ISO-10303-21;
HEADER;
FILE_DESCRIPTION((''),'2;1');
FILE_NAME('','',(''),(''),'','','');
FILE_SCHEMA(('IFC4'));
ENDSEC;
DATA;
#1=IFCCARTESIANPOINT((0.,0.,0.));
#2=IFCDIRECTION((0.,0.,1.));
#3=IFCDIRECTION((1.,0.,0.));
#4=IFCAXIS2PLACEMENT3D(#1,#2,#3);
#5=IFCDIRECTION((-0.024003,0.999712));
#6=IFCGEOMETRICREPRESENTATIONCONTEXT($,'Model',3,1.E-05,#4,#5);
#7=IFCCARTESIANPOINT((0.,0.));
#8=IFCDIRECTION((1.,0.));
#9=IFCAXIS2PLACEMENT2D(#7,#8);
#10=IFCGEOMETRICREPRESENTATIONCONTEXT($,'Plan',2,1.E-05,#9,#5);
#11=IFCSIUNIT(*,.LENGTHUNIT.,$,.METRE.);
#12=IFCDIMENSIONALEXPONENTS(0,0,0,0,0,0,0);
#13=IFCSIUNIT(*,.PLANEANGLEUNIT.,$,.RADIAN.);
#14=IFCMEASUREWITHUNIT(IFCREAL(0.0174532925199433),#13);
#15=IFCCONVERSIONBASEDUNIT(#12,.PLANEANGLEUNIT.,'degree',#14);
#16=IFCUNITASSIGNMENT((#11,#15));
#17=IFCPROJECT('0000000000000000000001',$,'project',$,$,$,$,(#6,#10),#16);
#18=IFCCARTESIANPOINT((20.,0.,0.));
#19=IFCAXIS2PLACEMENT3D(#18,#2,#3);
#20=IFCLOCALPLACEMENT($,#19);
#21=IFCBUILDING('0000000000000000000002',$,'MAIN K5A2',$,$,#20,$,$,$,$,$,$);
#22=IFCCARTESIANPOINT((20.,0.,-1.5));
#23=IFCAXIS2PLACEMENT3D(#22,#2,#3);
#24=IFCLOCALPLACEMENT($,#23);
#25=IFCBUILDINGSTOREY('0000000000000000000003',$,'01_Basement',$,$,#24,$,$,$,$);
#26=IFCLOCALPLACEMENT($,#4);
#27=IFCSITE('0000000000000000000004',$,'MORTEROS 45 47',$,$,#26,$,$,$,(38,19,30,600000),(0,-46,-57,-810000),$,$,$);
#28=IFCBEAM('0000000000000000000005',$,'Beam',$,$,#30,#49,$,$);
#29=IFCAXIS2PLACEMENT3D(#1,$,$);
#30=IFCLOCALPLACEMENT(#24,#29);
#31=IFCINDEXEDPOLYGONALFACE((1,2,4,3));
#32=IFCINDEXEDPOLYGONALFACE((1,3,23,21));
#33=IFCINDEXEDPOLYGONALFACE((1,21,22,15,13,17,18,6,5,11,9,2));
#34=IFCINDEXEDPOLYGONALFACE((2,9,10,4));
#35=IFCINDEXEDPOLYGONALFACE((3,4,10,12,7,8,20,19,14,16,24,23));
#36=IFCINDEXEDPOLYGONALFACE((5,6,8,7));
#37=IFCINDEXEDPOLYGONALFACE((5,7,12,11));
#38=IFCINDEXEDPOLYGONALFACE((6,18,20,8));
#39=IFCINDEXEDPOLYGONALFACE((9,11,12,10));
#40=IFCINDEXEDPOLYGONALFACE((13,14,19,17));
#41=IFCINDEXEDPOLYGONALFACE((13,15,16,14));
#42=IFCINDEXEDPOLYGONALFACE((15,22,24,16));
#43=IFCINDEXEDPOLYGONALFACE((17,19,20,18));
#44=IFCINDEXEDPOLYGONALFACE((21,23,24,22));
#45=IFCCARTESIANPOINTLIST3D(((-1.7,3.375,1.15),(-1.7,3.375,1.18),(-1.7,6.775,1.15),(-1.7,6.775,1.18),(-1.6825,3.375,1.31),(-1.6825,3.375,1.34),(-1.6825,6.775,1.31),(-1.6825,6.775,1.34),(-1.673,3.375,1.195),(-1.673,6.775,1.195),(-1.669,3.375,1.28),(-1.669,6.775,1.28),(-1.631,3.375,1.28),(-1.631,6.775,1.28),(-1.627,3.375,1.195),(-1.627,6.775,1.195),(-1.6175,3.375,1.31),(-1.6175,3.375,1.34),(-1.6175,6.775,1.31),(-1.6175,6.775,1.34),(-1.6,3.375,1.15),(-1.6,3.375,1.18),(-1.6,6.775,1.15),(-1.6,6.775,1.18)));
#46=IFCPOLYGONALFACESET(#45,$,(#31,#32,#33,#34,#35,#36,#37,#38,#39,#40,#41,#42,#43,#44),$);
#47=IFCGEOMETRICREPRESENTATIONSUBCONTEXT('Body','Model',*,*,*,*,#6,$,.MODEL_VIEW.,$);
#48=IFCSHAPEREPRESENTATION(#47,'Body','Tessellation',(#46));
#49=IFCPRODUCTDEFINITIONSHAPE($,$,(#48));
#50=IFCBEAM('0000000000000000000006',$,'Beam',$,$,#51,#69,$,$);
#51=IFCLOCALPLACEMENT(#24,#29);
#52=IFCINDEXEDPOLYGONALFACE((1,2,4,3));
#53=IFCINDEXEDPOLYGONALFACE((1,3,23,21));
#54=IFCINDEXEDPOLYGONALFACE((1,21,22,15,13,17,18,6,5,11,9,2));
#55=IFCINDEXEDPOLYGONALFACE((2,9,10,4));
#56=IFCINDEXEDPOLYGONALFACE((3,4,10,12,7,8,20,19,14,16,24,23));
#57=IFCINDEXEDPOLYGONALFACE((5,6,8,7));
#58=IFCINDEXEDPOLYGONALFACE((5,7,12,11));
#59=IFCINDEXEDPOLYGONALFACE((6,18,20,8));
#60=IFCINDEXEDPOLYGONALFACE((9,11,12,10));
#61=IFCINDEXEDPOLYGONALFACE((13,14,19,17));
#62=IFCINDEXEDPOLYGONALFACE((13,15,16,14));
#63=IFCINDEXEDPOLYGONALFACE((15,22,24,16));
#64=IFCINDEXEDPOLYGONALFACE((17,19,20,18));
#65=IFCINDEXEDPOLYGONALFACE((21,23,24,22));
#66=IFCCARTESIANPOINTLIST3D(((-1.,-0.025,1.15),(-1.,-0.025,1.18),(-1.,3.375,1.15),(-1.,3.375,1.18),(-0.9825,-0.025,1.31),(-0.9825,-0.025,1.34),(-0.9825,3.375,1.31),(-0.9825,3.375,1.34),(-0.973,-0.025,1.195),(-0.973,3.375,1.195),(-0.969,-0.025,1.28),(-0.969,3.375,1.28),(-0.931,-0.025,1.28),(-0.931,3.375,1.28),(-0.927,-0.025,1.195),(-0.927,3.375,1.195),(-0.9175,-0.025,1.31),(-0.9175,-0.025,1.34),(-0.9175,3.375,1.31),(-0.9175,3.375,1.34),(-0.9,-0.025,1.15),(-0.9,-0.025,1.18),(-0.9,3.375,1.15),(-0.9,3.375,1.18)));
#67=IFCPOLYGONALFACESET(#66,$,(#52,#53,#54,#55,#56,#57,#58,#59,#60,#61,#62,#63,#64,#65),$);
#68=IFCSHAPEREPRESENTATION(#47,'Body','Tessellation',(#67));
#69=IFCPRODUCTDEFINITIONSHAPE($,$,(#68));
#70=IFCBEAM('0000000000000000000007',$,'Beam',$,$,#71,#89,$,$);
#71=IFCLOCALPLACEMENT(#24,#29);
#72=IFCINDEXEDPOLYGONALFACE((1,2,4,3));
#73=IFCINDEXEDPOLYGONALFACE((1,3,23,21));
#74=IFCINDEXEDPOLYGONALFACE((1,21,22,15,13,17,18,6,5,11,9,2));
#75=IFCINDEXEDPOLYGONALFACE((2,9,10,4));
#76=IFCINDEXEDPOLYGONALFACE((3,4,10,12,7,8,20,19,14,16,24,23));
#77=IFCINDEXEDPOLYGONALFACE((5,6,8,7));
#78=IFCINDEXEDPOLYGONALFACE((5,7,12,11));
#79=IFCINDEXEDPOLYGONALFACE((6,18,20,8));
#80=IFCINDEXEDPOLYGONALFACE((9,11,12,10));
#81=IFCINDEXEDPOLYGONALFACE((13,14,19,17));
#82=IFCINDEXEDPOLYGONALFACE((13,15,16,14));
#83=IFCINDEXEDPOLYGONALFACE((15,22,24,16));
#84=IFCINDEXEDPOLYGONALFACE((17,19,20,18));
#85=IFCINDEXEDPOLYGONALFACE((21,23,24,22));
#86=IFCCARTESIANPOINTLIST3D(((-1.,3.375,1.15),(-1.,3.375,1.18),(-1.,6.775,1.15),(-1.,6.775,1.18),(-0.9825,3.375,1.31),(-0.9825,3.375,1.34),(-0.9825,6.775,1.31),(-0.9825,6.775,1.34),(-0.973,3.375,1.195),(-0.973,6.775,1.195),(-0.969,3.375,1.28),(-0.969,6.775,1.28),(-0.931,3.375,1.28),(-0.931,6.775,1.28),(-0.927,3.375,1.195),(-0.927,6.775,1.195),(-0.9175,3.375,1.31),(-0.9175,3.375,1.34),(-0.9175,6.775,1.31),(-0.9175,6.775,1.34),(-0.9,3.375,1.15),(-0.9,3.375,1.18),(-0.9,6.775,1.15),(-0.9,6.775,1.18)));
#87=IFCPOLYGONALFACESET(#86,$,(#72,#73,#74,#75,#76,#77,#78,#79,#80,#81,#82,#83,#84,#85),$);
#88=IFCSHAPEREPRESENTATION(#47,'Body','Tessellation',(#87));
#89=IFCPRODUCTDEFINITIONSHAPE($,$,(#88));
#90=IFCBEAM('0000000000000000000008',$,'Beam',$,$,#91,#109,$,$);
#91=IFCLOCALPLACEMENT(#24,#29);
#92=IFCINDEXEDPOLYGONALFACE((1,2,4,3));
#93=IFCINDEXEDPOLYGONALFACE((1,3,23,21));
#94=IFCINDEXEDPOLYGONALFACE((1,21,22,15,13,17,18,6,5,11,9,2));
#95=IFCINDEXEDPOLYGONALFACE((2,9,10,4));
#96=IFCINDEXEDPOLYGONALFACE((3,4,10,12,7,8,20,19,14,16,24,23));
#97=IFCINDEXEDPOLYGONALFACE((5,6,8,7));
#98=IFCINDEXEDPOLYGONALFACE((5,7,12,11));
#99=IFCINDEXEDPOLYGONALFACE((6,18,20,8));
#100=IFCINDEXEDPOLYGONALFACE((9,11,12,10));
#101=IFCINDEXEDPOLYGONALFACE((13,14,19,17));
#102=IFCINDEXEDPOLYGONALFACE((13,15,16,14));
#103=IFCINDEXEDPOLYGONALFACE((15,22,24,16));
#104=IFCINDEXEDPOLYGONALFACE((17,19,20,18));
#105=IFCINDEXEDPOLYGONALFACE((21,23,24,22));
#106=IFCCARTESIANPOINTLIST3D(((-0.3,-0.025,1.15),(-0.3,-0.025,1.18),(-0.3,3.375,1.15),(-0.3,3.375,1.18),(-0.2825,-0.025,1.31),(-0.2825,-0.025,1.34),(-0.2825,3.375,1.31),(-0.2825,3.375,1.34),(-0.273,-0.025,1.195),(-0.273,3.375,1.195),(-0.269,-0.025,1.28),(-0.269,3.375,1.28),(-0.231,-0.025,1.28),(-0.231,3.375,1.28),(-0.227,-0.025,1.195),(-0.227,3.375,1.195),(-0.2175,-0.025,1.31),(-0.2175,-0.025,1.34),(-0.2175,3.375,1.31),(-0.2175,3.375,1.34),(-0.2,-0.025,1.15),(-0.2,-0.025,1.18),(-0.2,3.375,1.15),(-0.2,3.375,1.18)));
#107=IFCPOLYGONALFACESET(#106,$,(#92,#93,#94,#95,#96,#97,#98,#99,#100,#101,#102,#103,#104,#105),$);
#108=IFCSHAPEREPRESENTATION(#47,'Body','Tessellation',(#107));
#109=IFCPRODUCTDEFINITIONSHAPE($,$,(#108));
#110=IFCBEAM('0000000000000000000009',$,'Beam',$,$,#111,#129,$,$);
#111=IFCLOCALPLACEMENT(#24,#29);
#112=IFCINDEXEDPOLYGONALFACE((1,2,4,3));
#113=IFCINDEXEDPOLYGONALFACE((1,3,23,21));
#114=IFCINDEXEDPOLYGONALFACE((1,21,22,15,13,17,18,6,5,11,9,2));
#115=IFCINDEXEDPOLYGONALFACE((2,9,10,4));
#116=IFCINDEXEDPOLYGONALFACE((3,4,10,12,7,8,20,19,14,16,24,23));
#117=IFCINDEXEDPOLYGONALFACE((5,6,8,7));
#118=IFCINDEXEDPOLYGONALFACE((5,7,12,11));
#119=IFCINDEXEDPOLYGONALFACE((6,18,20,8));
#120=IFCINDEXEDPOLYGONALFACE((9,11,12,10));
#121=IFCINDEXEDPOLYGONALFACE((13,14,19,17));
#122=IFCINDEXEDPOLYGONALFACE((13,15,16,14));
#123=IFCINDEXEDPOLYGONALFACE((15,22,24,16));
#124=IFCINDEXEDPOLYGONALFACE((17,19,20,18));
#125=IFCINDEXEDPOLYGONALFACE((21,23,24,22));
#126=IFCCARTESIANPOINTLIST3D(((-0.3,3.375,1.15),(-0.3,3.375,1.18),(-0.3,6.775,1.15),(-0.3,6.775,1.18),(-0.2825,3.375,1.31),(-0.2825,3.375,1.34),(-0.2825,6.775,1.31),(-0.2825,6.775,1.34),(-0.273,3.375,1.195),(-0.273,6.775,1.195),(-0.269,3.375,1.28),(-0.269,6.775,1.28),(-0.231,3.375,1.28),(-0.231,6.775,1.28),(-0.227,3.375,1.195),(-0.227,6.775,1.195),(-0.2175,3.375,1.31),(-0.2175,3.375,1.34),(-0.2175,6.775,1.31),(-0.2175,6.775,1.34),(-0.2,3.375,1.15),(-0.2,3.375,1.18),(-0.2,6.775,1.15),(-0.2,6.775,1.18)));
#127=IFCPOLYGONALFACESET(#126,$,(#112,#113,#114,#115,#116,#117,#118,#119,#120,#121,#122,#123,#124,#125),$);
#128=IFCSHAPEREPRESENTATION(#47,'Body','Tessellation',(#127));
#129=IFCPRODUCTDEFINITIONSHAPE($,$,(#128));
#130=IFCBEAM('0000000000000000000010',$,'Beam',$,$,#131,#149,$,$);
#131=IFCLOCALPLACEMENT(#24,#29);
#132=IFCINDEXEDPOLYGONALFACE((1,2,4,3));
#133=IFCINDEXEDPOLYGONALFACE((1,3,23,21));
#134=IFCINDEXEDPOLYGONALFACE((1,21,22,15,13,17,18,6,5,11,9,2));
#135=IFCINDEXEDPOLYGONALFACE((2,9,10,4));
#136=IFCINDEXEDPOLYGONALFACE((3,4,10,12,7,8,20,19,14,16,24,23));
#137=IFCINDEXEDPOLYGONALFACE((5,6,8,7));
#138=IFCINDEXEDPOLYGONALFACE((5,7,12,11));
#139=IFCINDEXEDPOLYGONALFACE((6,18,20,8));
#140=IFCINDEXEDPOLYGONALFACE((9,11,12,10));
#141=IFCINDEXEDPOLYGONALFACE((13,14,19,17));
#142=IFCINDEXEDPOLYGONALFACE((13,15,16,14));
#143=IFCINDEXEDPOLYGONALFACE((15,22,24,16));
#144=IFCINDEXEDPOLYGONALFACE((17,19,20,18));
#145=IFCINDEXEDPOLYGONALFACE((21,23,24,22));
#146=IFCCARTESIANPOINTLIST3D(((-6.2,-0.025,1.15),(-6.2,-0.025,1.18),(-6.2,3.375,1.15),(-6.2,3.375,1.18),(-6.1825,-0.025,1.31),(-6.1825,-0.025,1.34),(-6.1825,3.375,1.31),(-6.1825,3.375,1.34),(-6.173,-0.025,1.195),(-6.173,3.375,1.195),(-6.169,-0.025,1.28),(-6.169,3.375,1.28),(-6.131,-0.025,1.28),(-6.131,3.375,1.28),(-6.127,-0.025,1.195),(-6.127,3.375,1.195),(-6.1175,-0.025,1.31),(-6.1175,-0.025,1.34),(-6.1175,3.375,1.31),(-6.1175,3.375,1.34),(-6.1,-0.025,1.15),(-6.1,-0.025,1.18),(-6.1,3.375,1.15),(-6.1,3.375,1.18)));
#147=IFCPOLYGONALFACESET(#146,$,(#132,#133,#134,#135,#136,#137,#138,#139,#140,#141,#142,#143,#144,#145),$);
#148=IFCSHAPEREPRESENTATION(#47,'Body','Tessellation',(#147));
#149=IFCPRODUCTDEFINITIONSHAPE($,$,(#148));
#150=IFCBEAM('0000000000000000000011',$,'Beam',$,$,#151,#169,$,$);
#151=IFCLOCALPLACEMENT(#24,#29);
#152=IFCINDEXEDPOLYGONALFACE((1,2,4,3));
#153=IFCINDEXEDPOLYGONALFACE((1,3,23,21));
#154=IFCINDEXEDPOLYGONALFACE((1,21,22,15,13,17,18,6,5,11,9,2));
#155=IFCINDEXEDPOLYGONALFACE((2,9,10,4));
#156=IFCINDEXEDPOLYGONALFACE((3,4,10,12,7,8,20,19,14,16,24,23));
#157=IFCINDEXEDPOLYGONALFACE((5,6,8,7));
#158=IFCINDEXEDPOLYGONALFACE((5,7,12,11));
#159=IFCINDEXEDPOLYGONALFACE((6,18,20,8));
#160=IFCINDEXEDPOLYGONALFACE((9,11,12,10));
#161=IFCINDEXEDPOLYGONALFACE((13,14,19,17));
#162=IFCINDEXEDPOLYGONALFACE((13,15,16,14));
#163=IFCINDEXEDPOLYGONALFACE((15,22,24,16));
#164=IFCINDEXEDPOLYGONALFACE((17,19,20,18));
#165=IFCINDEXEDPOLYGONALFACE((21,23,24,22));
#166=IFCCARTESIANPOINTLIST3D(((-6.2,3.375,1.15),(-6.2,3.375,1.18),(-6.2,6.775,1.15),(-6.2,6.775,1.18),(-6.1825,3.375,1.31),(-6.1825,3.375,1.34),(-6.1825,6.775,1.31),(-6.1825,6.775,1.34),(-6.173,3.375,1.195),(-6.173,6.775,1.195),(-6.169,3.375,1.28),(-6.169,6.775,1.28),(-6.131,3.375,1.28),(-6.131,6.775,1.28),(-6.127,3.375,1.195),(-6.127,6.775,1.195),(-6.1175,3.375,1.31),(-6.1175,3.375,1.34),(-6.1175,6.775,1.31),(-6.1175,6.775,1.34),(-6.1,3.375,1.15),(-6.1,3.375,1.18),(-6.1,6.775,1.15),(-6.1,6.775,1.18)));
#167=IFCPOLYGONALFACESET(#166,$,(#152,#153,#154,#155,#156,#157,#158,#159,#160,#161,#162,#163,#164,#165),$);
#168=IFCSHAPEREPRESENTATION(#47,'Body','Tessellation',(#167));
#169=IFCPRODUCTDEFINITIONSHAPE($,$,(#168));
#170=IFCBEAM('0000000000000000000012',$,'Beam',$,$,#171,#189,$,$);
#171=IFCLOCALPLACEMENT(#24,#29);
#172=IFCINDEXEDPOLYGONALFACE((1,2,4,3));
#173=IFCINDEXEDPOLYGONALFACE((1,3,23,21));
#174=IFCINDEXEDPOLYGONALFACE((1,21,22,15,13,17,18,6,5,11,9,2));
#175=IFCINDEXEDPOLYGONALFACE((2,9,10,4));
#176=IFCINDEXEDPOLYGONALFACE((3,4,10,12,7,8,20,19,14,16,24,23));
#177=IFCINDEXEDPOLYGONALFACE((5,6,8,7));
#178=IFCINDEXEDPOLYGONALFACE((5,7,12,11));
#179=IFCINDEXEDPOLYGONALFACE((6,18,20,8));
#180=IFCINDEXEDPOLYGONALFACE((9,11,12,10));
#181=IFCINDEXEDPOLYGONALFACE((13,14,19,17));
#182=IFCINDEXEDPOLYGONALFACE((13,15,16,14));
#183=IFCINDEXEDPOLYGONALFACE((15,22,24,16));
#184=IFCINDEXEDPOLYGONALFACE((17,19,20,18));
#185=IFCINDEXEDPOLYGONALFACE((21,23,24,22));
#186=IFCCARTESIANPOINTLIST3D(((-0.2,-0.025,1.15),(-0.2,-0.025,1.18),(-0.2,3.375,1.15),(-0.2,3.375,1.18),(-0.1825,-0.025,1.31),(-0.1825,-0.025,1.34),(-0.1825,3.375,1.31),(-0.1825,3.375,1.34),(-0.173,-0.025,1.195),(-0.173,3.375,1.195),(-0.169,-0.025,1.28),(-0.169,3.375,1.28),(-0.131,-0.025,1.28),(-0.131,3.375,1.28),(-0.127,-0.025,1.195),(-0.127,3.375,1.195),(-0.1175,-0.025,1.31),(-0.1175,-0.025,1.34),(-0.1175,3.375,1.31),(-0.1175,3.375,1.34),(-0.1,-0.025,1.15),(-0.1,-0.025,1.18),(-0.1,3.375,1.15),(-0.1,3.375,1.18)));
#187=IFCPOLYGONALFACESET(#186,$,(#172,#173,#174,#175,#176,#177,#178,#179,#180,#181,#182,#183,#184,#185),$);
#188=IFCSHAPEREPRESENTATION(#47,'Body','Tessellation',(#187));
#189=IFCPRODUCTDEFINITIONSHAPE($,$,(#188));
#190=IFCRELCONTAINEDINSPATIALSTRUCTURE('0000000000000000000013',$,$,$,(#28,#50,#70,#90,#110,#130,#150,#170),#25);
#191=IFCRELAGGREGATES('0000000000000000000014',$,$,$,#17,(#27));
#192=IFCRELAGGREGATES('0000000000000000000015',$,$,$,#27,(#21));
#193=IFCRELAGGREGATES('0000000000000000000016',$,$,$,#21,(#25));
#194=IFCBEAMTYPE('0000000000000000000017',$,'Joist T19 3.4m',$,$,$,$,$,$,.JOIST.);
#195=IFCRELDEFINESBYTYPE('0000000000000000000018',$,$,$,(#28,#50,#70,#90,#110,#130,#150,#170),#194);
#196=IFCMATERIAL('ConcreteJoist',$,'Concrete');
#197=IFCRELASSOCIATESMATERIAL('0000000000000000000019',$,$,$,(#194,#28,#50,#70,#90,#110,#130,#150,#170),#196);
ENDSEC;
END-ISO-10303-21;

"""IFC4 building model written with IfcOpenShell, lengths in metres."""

from ifc_helpers import new_model, entity, si_unit, converted_unit, direction, frame, origin_with_axes, origin_2d_with_axis, place, context, subcontext, project, spatial, indexed_curve, outline, extrude, material, material_profile, profile_set, profile_usage, type_object, element, save


model = new_model("IFC4")

# Units and contexts
model_context = context("Model", 3, precision=1e-05, world=origin_with_axes(), true_north=direction((-0.024003, 0.999712)))
plan_context = context("Plan", 2, precision=1e-05, world=origin_2d_with_axis(), true_north=direction((-0.024003, 0.999712)))
body_context = subcontext(model_context, "Body", "Model", "MODEL_VIEW")
ifc_project = project(units=[si_unit("LENGTHUNIT", "METRE"), converted_unit("PLANEANGLEUNIT", "degree", entity("IfcReal", 0.0174532925199433), si_unit("PLANEANGLEUNIT", "RADIAN"), dimensions=[0, 0, 0, 0, 0, 0, 0])], contexts=[model_context, plan_context])

# Site, building, storey
site_placement = place(None, origin_with_axes())
site = spatial("IfcSite", under=ifc_project, at=site_placement, Name="MORTEROS 45 47", RefLatitude=(38, 19, 30, 600000), RefLongitude=(0, -46, -57, -810000))
building_placement = place(None, frame((20.0, 0.0, 0.0), z_axis=(0.0, 0.0, 1.0), x_axis=(1.0, 0.0, 0.0)))
building = spatial("IfcBuilding", under=site, at=building_placement, Name="MAIN K5A2")
storey_placement = place(None, frame((20.0, 0.0, -1.5), z_axis=(0.0, 0.0, 1.0), x_axis=(1.0, 0.0, 0.0)))
storey = spatial("IfcBuildingStorey", under=building, at=storey_placement, Name="01_Basement")

# Beams
ifc_material = material(Name="ConcreteJoist", Category="Concrete")
ifc_material_profile = material_profile(ifc_material, outline(indexed_curve([(0.019, 0.13), (0.023, 0.045), (0.05, 0.03), (0.05, 0.0), (-0.05, 0.0), (-0.05, 0.03), (-0.023, 0.045), (-0.019, 0.13), (-0.0325, 0.16), (-0.0325, 0.19), (0.0325, 0.19), (0.0325, 0.16), (0.019, 0.13)])))
ifc_profile_set = profile_set([ifc_material_profile], Name="JoistMaterialProfileSet")
beam_type = type_object("IfcBeamType", Name="Joist T19 3.4m", PredefinedType="JOIST", material=ifc_profile_set)
ifc_profile_usage_1 = profile_usage(ifc_profile_set, cardinal=5)
beam_1_placement = place(None, frame((18.35, 3.375, -0.35), z_axis=(0.0, 1.0, 0.0), x_axis=(-1.0, 0.0, 0.0)))
element("IfcBeam", 1, at=beam_1_placement, inside=storey, type_object=beam_type, material=ifc_profile_usage_1, Name="Beam", context=body_context, shape_type="SweptSolid", body=[
    extrude(outline(indexed_curve([(0.019, 0.13), (0.023, 0.045), (0.05, 0.03), (0.05, 0.0), (-0.05, 0.0), (-0.05, 0.03), (-0.023, 0.045), (-0.019, 0.13), (-0.0325, 0.16), (-0.0325, 0.19), (0.0325, 0.19), (0.0325, 0.16), (0.019, 0.13)])), origin_with_axes(), (0.0, 0.0, 1.0), 3.4),
])
ifc_profile_usage_2 = profile_usage(ifc_profile_set, cardinal=5)
beam_2_placement = place(None, frame((19.05, -0.025, -0.35), z_axis=(0.0, 1.0, 0.0), x_axis=(-1.0, 0.0, 0.0)))
element("IfcBeam", 2, at=beam_2_placement, inside=storey, type_object=beam_type, material=ifc_profile_usage_2, Name="Beam", context=body_context, shape_type="SweptSolid", body=[
    extrude(outline(indexed_curve([(0.019, 0.13), (0.023, 0.045), (0.05, 0.03), (0.05, 0.0), (-0.05, 0.0), (-0.05, 0.03), (-0.023, 0.045), (-0.019, 0.13), (-0.0325, 0.16), (-0.0325, 0.19), (0.0325, 0.19), (0.0325, 0.16), (0.019, 0.13)])), origin_with_axes(), (0.0, 0.0, 1.0), 3.4),
])
ifc_profile_usage_3 = profile_usage(ifc_profile_set, cardinal=5)
beam_3_placement = place(None, frame((19.05, 3.375, -0.35), z_axis=(0.0, 1.0, 0.0), x_axis=(-1.0, 0.0, 0.0)))
element("IfcBeam", 3, at=beam_3_placement, inside=storey, type_object=beam_type, material=ifc_profile_usage_3, Name="Beam", context=body_context, shape_type="SweptSolid", body=[
    extrude(outline(indexed_curve([(0.019, 0.13), (0.023, 0.045), (0.05, 0.03), (0.05, 0.0), (-0.05, 0.0), (-0.05, 0.03), (-0.023, 0.045), (-0.019, 0.13), (-0.0325, 0.16), (-0.0325, 0.19), (0.0325, 0.19), (0.0325, 0.16), (0.019, 0.13)])), origin_with_axes(), (0.0, 0.0, 1.0), 3.4),
])
ifc_profile_usage_4 = profile_usage(ifc_profile_set, cardinal=5)
beam_4_placement = place(None, frame((19.75, -0.025, -0.35), z_axis=(0.0, 1.0, 0.0), x_axis=(-1.0, 0.0, 0.0)))
element("IfcBeam", 4, at=beam_4_placement, inside=storey, type_object=beam_type, material=ifc_profile_usage_4, Name="Beam", context=body_context, shape_type="SweptSolid", body=[
    extrude(outline(indexed_curve([(0.019, 0.13), (0.023, 0.045), (0.05, 0.03), (0.05, 0.0), (-0.05, 0.0), (-0.05, 0.03), (-0.023, 0.045), (-0.019, 0.13), (-0.0325, 0.16), (-0.0325, 0.19), (0.0325, 0.19), (0.0325, 0.16), (0.019, 0.13)])), origin_with_axes(), (0.0, 0.0, 1.0), 3.4),
])
ifc_profile_usage_5 = profile_usage(ifc_profile_set, cardinal=5)
beam_5_placement = place(None, frame((19.75, 3.375, -0.35), z_axis=(0.0, 1.0, 0.0), x_axis=(-1.0, 0.0, 0.0)))
element("IfcBeam", 5, at=beam_5_placement, inside=storey, type_object=beam_type, material=ifc_profile_usage_5, Name="Beam", context=body_context, shape_type="SweptSolid", body=[
    extrude(outline(indexed_curve([(0.019, 0.13), (0.023, 0.045), (0.05, 0.03), (0.05, 0.0), (-0.05, 0.0), (-0.05, 0.03), (-0.023, 0.045), (-0.019, 0.13), (-0.0325, 0.16), (-0.0325, 0.19), (0.0325, 0.19), (0.0325, 0.16), (0.019, 0.13)])), origin_with_axes(), (0.0, 0.0, 1.0), 3.4),
])
ifc_profile_usage_6 = profile_usage(ifc_profile_set, cardinal=5)
beam_6_placement = place(None, frame((13.85, -0.025, -0.35), z_axis=(0.0, 1.0, 0.0), x_axis=(-1.0, 0.0, 0.0)))
element("IfcBeam", 6, at=beam_6_placement, inside=storey, type_object=beam_type, material=ifc_profile_usage_6, Name="Beam", context=body_context, shape_type="SweptSolid", body=[
    extrude(outline(indexed_curve([(0.019, 0.13), (0.023, 0.045), (0.05, 0.03), (0.05, 0.0), (-0.05, 0.0), (-0.05, 0.03), (-0.023, 0.045), (-0.019, 0.13), (-0.0325, 0.16), (-0.0325, 0.19), (0.0325, 0.19), (0.0325, 0.16), (0.019, 0.13)])), origin_with_axes(), (0.0, 0.0, 1.0), 3.4),
])
ifc_profile_usage_7 = profile_usage(ifc_profile_set, cardinal=5)
beam_7_placement = place(None, frame((13.85, 3.375, -0.35), z_axis=(0.0, 1.0, 0.0), x_axis=(-1.0, 0.0, 0.0)))
element("IfcBeam", 7, at=beam_7_placement, inside=storey, type_object=beam_type, material=ifc_profile_usage_7, Name="Beam", context=body_context, shape_type="SweptSolid", body=[
    extrude(outline(indexed_curve([(0.019, 0.13), (0.023, 0.045), (0.05, 0.03), (0.05, 0.0), (-0.05, 0.0), (-0.05, 0.03), (-0.023, 0.045), (-0.019, 0.13), (-0.0325, 0.16), (-0.0325, 0.19), (0.0325, 0.19), (0.0325, 0.16), (0.019, 0.13)])), origin_with_axes(), (0.0, 0.0, 1.0), 3.4),
])
ifc_profile_usage_8 = profile_usage(ifc_profile_set, cardinal=5)
beam_8_placement = place(None, frame((19.85, -0.025, -0.35), z_axis=(0.0, 1.0, 0.0), x_axis=(-1.0, 0.0, 0.0)))
element("IfcBeam", 8, at=beam_8_placement, inside=storey, type_object=beam_type, material=ifc_profile_usage_8, Name="Beam", context=body_context, shape_type="SweptSolid", body=[
    extrude(outline(indexed_curve([(0.019, 0.13), (0.023, 0.045), (0.05, 0.03), (0.05, 0.0), (-0.05, 0.0), (-0.05, 0.03), (-0.023, 0.045), (-0.019, 0.13), (-0.0325, 0.16), (-0.0325, 0.19), (0.0325, 0.19), (0.0325, 0.16), (0.019, 0.13)])), origin_with_axes(), (0.0, 0.0, 1.0), 3.4),
])

save(model, "model.ifc")
